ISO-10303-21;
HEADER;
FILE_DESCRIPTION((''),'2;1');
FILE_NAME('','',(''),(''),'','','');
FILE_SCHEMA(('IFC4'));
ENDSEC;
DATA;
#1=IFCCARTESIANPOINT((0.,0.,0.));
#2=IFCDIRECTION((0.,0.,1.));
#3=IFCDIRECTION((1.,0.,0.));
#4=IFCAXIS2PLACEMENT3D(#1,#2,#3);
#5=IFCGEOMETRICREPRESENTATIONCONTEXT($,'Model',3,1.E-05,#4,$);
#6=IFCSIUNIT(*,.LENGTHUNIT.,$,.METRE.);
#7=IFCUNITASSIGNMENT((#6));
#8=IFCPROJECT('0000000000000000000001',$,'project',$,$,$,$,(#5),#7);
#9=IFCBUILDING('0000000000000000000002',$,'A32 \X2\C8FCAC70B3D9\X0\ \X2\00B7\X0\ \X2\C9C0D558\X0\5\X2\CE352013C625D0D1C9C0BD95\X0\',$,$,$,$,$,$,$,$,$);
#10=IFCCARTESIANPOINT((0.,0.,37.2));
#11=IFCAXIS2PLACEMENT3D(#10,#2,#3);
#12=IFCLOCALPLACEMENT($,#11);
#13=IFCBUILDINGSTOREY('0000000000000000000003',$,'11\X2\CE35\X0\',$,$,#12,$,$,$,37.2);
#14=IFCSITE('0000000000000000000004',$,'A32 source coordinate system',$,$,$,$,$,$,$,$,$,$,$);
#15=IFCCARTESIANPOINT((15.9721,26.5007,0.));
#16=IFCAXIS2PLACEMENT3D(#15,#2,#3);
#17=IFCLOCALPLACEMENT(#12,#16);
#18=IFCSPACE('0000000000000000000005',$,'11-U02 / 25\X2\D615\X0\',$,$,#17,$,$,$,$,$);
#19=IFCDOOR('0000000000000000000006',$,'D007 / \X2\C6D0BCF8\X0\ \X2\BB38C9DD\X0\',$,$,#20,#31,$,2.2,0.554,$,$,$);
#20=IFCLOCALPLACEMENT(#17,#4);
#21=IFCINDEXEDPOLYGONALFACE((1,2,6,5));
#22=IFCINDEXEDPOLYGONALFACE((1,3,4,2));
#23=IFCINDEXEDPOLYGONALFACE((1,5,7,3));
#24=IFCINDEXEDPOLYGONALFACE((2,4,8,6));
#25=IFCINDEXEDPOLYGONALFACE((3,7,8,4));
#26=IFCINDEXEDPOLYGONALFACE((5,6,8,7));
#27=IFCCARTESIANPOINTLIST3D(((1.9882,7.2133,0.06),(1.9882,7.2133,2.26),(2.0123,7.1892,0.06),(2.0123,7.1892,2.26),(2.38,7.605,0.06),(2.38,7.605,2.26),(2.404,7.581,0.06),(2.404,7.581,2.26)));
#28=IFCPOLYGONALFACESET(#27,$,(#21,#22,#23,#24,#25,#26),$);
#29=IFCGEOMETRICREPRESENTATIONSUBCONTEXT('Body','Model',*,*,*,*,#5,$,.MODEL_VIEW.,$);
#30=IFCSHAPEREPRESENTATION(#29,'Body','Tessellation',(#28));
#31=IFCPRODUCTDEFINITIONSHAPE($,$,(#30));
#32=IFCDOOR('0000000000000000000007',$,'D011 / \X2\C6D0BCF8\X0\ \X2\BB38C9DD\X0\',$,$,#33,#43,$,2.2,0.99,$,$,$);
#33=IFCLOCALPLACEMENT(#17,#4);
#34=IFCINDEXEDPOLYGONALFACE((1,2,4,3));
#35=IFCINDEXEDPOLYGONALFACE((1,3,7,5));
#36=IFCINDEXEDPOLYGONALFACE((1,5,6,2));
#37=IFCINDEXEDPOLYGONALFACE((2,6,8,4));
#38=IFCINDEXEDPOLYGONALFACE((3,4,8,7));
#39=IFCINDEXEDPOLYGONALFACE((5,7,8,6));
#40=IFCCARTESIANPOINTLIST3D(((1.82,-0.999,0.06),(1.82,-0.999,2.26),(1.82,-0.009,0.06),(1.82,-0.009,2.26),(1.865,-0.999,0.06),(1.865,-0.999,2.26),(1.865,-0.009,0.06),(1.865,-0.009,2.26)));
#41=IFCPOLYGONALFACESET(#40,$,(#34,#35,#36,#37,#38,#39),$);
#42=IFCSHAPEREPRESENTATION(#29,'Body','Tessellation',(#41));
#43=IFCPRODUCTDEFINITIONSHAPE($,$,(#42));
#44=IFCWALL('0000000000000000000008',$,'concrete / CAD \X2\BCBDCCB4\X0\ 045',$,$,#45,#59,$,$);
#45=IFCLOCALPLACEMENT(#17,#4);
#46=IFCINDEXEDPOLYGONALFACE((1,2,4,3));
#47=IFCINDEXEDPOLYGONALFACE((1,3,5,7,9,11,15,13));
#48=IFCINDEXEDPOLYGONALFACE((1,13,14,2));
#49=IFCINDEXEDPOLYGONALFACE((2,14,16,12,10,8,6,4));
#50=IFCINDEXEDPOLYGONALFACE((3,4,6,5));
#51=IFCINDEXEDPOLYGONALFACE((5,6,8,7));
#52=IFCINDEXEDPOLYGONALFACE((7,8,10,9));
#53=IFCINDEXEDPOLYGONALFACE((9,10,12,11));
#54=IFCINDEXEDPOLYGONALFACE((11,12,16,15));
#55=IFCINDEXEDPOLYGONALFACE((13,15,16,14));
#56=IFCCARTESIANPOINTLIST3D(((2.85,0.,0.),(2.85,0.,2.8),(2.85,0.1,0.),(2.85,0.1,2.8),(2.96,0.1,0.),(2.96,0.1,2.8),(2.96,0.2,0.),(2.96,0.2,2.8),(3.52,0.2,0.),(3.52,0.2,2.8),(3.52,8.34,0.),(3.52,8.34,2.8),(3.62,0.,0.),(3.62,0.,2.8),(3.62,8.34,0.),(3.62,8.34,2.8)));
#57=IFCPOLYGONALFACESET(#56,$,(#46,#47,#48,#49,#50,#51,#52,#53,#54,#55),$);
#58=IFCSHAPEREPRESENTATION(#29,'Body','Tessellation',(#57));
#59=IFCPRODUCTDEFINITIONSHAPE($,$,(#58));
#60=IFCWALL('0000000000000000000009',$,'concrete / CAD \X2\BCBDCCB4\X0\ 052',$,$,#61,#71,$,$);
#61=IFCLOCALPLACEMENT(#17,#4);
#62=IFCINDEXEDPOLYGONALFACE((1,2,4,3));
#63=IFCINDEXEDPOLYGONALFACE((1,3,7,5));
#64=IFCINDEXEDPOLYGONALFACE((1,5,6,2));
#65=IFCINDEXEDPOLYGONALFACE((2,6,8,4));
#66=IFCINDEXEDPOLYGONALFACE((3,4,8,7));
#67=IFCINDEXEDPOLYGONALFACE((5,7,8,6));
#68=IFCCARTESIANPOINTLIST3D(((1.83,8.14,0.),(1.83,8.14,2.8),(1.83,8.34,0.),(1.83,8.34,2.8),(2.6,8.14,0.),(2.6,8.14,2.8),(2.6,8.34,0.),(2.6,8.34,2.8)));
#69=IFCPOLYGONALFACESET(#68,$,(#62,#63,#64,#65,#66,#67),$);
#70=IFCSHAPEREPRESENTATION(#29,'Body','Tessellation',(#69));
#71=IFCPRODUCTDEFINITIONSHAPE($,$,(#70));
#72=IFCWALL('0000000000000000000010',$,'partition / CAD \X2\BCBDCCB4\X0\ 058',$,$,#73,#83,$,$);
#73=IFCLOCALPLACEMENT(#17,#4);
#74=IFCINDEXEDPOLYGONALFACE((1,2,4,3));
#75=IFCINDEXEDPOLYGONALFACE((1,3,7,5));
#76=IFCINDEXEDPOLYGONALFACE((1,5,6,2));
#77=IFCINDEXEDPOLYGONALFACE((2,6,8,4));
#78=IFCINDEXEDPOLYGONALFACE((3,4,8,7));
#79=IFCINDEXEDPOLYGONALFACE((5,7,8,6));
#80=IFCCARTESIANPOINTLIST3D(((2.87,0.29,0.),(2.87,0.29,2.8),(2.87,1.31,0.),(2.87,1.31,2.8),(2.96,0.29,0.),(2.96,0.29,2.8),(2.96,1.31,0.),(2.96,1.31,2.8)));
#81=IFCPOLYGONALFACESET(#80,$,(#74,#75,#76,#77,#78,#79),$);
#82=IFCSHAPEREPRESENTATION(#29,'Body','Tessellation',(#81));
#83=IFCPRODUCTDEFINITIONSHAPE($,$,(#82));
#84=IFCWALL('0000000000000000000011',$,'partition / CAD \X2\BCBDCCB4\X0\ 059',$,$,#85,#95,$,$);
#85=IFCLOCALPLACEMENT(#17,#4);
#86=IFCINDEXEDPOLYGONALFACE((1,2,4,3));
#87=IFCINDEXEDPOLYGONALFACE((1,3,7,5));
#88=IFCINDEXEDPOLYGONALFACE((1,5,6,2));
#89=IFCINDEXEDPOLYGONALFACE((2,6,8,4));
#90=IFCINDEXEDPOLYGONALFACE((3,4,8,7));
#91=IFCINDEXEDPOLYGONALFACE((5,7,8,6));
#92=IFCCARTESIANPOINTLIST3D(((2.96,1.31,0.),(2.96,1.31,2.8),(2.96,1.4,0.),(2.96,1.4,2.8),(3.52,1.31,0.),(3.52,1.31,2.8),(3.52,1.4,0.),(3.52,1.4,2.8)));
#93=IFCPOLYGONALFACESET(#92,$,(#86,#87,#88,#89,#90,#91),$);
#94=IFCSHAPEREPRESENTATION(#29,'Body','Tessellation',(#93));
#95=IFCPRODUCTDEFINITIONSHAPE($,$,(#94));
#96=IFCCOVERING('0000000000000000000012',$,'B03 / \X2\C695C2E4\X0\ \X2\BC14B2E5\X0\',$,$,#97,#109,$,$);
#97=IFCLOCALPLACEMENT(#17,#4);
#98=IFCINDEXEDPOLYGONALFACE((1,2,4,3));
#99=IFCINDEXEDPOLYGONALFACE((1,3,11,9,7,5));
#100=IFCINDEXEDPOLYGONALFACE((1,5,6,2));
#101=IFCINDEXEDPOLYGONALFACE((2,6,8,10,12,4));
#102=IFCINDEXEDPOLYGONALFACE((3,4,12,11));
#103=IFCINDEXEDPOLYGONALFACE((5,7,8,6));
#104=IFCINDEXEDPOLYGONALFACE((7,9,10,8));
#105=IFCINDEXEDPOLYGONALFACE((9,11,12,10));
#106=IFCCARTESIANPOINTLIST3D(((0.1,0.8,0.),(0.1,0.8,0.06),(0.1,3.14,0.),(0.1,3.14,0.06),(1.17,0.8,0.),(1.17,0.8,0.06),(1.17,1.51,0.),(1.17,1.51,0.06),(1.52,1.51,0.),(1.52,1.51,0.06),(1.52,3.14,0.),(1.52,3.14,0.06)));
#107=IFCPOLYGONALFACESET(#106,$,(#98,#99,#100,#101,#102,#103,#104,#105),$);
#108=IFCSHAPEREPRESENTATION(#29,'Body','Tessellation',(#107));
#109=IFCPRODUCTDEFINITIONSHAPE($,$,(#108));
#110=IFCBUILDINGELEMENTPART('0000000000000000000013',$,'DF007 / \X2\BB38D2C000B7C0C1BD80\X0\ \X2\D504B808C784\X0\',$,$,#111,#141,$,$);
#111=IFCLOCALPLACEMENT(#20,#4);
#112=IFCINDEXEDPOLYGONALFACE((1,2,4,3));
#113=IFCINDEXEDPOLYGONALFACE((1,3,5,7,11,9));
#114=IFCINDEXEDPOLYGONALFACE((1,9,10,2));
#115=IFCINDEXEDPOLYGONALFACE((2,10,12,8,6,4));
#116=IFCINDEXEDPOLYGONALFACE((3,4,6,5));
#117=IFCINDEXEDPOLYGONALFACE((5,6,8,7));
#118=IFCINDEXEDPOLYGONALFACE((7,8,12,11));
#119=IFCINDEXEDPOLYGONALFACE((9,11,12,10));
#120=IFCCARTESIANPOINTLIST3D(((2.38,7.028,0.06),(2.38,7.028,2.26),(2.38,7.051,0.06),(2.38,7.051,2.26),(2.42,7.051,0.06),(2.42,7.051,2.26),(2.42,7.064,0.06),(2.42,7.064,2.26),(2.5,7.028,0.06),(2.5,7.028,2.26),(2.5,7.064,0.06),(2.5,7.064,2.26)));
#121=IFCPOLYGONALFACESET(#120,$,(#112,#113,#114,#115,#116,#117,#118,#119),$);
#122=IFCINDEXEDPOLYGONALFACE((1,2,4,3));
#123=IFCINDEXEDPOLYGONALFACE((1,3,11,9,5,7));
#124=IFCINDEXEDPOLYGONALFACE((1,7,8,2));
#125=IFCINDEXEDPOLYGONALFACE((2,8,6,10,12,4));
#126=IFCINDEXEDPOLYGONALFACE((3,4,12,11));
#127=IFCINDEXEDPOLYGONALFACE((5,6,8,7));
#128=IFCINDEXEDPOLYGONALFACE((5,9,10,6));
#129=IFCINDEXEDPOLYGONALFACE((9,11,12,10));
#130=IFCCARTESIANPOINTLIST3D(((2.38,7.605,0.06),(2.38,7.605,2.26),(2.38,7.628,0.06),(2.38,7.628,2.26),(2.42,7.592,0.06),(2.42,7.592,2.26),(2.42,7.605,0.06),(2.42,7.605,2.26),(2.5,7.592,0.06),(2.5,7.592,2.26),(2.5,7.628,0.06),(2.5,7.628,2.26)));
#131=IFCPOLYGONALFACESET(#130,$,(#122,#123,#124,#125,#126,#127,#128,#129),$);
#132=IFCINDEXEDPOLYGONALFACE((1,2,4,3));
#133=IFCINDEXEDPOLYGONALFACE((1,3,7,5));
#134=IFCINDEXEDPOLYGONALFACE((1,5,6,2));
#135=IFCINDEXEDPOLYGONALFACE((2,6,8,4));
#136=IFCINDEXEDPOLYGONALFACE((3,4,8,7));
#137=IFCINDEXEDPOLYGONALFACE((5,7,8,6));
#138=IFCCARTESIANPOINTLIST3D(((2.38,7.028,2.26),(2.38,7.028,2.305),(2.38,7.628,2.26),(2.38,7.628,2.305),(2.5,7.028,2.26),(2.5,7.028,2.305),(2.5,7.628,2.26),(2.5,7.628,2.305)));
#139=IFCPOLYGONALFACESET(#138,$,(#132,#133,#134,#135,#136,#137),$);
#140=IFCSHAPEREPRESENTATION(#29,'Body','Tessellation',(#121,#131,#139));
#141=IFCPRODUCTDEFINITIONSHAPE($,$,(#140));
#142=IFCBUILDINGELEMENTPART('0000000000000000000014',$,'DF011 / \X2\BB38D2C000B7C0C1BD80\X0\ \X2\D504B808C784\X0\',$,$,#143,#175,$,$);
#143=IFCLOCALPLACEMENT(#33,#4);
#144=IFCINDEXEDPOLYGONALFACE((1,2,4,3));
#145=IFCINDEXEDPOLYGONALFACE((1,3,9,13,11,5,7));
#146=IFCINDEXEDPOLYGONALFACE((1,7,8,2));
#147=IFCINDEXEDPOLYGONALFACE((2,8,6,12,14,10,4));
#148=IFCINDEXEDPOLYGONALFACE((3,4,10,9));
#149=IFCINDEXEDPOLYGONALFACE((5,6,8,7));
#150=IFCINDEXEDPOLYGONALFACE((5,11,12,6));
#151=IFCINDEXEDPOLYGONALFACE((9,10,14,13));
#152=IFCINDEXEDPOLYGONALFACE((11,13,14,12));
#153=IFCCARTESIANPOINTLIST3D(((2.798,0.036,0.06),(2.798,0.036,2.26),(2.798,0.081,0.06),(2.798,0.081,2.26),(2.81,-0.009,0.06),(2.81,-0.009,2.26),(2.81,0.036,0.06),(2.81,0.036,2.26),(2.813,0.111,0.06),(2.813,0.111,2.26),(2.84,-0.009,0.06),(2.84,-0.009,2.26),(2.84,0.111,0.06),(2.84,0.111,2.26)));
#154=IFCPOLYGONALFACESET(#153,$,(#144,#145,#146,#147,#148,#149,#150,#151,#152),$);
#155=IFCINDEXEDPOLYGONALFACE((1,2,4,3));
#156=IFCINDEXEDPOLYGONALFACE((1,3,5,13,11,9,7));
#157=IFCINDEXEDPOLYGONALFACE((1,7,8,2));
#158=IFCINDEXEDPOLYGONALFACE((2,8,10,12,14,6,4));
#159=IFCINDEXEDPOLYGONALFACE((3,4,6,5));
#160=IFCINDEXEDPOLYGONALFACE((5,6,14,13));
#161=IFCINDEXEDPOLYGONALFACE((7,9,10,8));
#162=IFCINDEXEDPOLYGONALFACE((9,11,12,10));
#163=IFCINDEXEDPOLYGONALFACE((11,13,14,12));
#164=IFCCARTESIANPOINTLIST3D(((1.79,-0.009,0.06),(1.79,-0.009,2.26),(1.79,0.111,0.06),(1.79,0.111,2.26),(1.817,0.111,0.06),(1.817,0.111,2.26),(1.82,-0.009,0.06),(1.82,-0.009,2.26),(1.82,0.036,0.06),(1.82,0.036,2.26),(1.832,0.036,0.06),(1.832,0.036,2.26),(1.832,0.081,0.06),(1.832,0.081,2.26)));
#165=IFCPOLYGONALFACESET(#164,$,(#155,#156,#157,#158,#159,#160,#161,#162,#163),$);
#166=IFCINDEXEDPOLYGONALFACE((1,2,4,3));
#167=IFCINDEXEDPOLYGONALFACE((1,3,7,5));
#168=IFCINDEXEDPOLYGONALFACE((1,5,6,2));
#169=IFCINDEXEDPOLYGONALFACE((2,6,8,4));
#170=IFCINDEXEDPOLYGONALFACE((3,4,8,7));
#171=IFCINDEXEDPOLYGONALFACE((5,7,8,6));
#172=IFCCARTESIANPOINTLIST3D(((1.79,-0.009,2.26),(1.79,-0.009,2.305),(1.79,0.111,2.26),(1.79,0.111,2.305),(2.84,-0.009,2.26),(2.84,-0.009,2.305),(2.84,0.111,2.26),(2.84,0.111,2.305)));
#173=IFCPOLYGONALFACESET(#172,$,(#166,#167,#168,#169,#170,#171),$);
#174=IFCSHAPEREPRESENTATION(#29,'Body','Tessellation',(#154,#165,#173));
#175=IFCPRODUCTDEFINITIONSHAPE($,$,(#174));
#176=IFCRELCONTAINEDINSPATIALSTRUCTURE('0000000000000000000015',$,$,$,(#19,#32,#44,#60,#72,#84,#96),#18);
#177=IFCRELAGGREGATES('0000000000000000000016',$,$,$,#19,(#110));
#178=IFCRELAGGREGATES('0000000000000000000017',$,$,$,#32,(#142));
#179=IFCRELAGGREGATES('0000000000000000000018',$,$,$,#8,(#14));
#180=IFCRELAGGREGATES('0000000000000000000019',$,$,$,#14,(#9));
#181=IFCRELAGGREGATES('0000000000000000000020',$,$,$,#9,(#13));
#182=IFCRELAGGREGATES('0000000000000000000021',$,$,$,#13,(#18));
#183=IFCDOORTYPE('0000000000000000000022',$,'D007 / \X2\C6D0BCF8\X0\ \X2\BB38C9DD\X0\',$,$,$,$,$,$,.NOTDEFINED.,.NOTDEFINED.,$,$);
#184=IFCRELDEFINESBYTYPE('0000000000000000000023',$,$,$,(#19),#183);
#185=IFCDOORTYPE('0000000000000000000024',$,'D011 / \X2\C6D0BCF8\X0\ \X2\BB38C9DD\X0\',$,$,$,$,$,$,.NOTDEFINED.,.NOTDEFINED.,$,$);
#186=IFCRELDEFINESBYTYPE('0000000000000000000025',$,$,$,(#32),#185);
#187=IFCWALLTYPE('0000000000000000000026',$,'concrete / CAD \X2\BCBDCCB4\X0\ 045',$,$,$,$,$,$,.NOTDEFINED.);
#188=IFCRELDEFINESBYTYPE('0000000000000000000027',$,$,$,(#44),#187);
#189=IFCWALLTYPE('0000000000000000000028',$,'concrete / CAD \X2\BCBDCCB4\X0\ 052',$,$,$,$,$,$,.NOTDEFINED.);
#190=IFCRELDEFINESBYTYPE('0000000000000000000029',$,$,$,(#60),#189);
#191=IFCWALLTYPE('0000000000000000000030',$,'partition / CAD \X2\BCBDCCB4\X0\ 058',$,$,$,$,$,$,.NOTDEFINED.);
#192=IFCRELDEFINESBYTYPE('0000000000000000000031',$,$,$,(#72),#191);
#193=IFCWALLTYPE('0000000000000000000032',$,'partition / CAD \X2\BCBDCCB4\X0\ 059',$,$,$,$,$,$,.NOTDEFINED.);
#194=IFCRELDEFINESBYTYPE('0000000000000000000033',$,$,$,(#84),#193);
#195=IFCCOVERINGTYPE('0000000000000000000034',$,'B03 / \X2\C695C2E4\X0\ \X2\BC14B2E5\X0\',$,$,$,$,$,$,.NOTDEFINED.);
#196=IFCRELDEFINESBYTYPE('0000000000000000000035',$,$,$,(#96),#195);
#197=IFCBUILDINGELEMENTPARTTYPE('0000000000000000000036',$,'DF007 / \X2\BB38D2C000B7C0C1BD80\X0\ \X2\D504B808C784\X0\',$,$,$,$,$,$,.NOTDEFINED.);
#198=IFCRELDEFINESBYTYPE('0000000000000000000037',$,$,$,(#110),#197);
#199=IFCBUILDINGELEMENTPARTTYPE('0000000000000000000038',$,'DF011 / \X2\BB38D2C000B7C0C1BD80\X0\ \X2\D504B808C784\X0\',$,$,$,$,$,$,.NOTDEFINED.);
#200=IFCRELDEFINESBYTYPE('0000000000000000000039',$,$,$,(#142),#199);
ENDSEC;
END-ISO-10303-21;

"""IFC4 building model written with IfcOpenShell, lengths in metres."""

from ifc_helpers import new_model, si_unit, frame, origin, origin_with_axes, place, context, subcontext, project, spatial, polyline, outline, extrude, source, transform, mapped, type_object, type_shapes, element, aggregate, save


model = new_model("IFC4")

# Units and contexts
model_context = context("Model", 3, precision=1e-05, world=origin_with_axes())
body_context = subcontext(model_context, "Body", "Model", "MODEL_VIEW")
ifc_project = project(units=[si_unit("LENGTHUNIT", "METRE")], contexts=[model_context])

# Site, building, storey, space
storey_placement = place(None, frame((0.0, 0.0, 37.2), z_axis=(0.0, 0.0, 1.0), x_axis=(1.0, 0.0, 0.0)))
space_placement = place(storey_placement, frame((15.9721, 26.5007, 0.0), z_axis=(0.0, 0.0, 1.0), x_axis=(1.0, 0.0, 0.0)))
site = spatial("IfcSite", under=ifc_project, Name="A32 source coordinate system")
building = spatial("IfcBuilding", under=site, Name="A32 주거동 · 지하5층–옥탑지붕")
storey = spatial("IfcBuildingStorey", under=building, at=storey_placement, Name="11층", Elevation=37.2)
space = spatial("IfcSpace", under=storey, at=space_placement, Name="11-U02 / 25형")

# Doors
door_type_1 = type_object("IfcDoorType", Name="D007 / 원본 문짝", OperationType="NOTDEFINED", PredefinedType="NOTDEFINED")
shared_shape_1 = source(origin(), body_context, "Body", "SweptSolid", [
    extrude(outline(polyline([(2.0123, 7.1892), (1.9882, 7.2133), (2.38, 7.605), (2.404, 7.581), (2.0123, 7.1892)])), frame((0.0, 0.0, 0.06)), (0.0, 0.0, 1.0), 2.2),
])
type_shapes(door_type_1, [shared_shape_1])
door_1_placement = place(space_placement, origin_with_axes())
door_1 = element("IfcDoor", 1, at=door_1_placement, inside=space, type_object=door_type_1, Name="D007 / 원본 문짝", OverallHeight=2.2, OverallWidth=0.554, context=body_context, shape_type="MappedRepresentation", body=[
    mapped(shared_shape_1, transform((0.0, 0.0, 0.0), scale=1.0)),
])
door_type_2 = type_object("IfcDoorType", Name="D011 / 원본 문짝", OperationType="NOTDEFINED", PredefinedType="NOTDEFINED")
shared_shape_2 = source(origin(), body_context, "Body", "SweptSolid", [
    extrude(outline(polyline([(1.865, -0.999), (1.82, -0.999), (1.82, -0.009), (1.865, -0.009), (1.865, -0.999)])), frame((0.0, 0.0, 0.06)), (0.0, 0.0, 1.0), 2.2),
])
type_shapes(door_type_2, [shared_shape_2])
door_2_placement = place(space_placement, origin_with_axes())
door_2 = element("IfcDoor", 2, at=door_2_placement, inside=space, type_object=door_type_2, Name="D011 / 원본 문짝", OverallHeight=2.2, OverallWidth=0.99, context=body_context, shape_type="MappedRepresentation", body=[
    mapped(shared_shape_2, transform((0.0, 0.0, 0.0), scale=1.0)),
])

# Walls
wall_type_1 = type_object("IfcWallType", Name="concrete / CAD 벽체 045", PredefinedType="NOTDEFINED")
shared_shape_3 = source(origin(), body_context, "Body", "SweptSolid", [
    extrude(outline(polyline([(2.96, 0.1), (2.96, 0.2), (3.52, 0.2), (3.52, 8.34), (3.72, 8.34), (3.72, 8.34), (3.62, 8.34), (3.62, 0.0), (2.85, 0.0), (2.85, 0.1), (2.96, 0.1)])), origin(), (0.0, 0.0, 1.0), 2.8),
])
type_shapes(wall_type_1, [shared_shape_3])
wall_1_placement = place(space_placement, origin_with_axes())
element("IfcWall", 3, at=wall_1_placement, inside=space, type_object=wall_type_1, Name="concrete / CAD 벽체 045", context=body_context, shape_type="MappedRepresentation", body=[
    mapped(shared_shape_3, transform((0.0, 0.0, 0.0), scale=1.0)),
])
wall_type_2 = type_object("IfcWallType", Name="concrete / CAD 벽체 052", PredefinedType="NOTDEFINED")
shared_shape_4 = source(origin(), body_context, "Body", "SweptSolid", [
    extrude(outline(polyline([(2.6, 8.14), (1.83, 8.14), (1.83, 8.34), (2.6, 8.34), (2.6, 8.14)])), origin(), (0.0, 0.0, 1.0), 2.8),
])
type_shapes(wall_type_2, [shared_shape_4])
wall_2_placement = place(space_placement, origin_with_axes())
element("IfcWall", 4, at=wall_2_placement, inside=space, type_object=wall_type_2, Name="concrete / CAD 벽체 052", context=body_context, shape_type="MappedRepresentation", body=[
    mapped(shared_shape_4, transform((0.0, 0.0, 0.0), scale=1.0)),
])
wall_type_3 = type_object("IfcWallType", Name="partition / CAD 벽체 058", PredefinedType="NOTDEFINED")
shared_shape_5 = source(origin(), body_context, "Body", "SweptSolid", [
    extrude(outline(polyline([(2.96, 1.31), (2.96, 0.29), (2.87, 0.29), (2.87, 1.31), (2.96, 1.31)])), origin(), (0.0, 0.0, 1.0), 2.8),
])
type_shapes(wall_type_3, [shared_shape_5])
wall_3_placement = place(space_placement, origin_with_axes())
element("IfcWall", 5, at=wall_3_placement, inside=space, type_object=wall_type_3, Name="partition / CAD 벽체 058", context=body_context, shape_type="MappedRepresentation", body=[
    mapped(shared_shape_5, transform((0.0, 0.0, 0.0), scale=1.0)),
])
wall_type_4 = type_object("IfcWallType", Name="partition / CAD 벽체 059", PredefinedType="NOTDEFINED")
shared_shape_6 = source(origin(), body_context, "Body", "SweptSolid", [
    extrude(outline(polyline([(3.52, 1.31), (2.96, 1.31), (2.96, 1.4), (3.52, 1.4), (3.52, 1.31)])), origin(), (0.0, 0.0, 1.0), 2.8),
])
type_shapes(wall_type_4, [shared_shape_6])
wall_4_placement = place(space_placement, origin_with_axes())
element("IfcWall", 6, at=wall_4_placement, inside=space, type_object=wall_type_4, Name="partition / CAD 벽체 059", context=body_context, shape_type="MappedRepresentation", body=[
    mapped(shared_shape_6, transform((0.0, 0.0, 0.0), scale=1.0)),
])

# Covering
covering_type_1 = type_object("IfcCoveringType", Name="B03 / 욕실 바닥", PredefinedType="NOTDEFINED")
shared_shape_7 = source(origin(), body_context, "Body", "SweptSolid", [
    extrude(outline(polyline([(1.17, 1.51), (1.17, 0.8), (0.1, 0.8), (0.1, 3.14), (1.52, 3.14), (1.52, 1.51), (1.17, 1.51)])), origin(), (0.0, 0.0, 1.0), 0.06),
])
type_shapes(covering_type_1, [shared_shape_7])
covering_1_placement = place(space_placement, origin_with_axes())
element("IfcCovering", 7, at=covering_1_placement, inside=space, type_object=covering_type_1, Name="B03 / 욕실 바닥", context=body_context, shape_type="MappedRepresentation", body=[
    mapped(shared_shape_7, transform((0.0, 0.0, 0.0), scale=1.0)),
])

# Building element parts
building_element_part_type_1 = type_object("IfcBuildingElementPartType", Name="DF007 / 문틀·상부 프레임", PredefinedType="NOTDEFINED")
shared_shape_8 = source(origin(), body_context, "Body", "SweptSolid", [
    extrude(outline(polyline([(2.38, 7.028), (2.38, 7.051), (2.42, 7.051), (2.42, 7.064), (2.5, 7.064), (2.5, 7.028), (2.38, 7.028)])), frame((0.0, 0.0, 0.06)), (0.0, 0.0, 1.0), 2.2),
    extrude(outline(polyline([(2.5, 7.592), (2.42, 7.592), (2.42, 7.605), (2.38, 7.605), (2.38, 7.628), (2.5, 7.628), (2.5, 7.592)])), frame((0.0, 0.0, 0.06)), (0.0, 0.0, 1.0), 2.2),
    extrude(outline(polyline([(2.38, 7.028), (2.38, 7.628), (2.5, 7.628), (2.5, 7.028), (2.38, 7.028)])), frame((0.0, 0.0, 2.26)), (0.0, 0.0, 1.0), 0.045),
])
type_shapes(building_element_part_type_1, [shared_shape_8])
building_element_part_1_placement = place(door_1_placement, origin_with_axes())
building_element_part_1 = element("IfcBuildingElementPart", 8, at=building_element_part_1_placement, type_object=building_element_part_type_1, Name="DF007 / 문틀·상부 프레임", context=body_context, shape_type="MappedRepresentation", body=[
    mapped(shared_shape_8, transform((0.0, 0.0, 0.0), scale=1.0)),
])
aggregate(door_1, [building_element_part_1])
building_element_part_type_2 = type_object("IfcBuildingElementPartType", Name="DF011 / 문틀·상부 프레임", PredefinedType="NOTDEFINED")
shared_shape_9 = source(origin(), body_context, "Body", "SweptSolid", [
    extrude(outline(polyline([(2.81, -0.009), (2.81, 0.036), (2.798, 0.036), (2.798, 0.081), (2.813, 0.111), (2.84, 0.111), (2.84, -0.009), (2.81, -0.009)])), frame((0.0, 0.0, 0.06)), (0.0, 0.0, 1.0), 2.2),
    extrude(outline(polyline([(1.79, 0.111), (1.817, 0.111), (1.832, 0.081), (1.832, 0.036), (1.82, 0.036), (1.82, -0.009), (1.79, -0.009), (1.79, 0.111)])), frame((0.0, 0.0, 0.06)), (0.0, 0.0, 1.0), 2.2),
    extrude(outline(polyline([(1.79, -0.009), (1.79, 0.111), (2.84, 0.111), (2.84, -0.009), (1.79, -0.009)])), frame((0.0, 0.0, 2.26)), (0.0, 0.0, 1.0), 0.045),
])
type_shapes(building_element_part_type_2, [shared_shape_9])
building_element_part_2_placement = place(door_2_placement, origin_with_axes())
building_element_part_2 = element("IfcBuildingElementPart", 9, at=building_element_part_2_placement, type_object=building_element_part_type_2, Name="DF011 / 문틀·상부 프레임", context=body_context, shape_type="MappedRepresentation", body=[
    mapped(shared_shape_9, transform((0.0, 0.0, 0.0), scale=1.0)),
])
aggregate(door_2, [building_element_part_2])

save(model, "model.ifc")
